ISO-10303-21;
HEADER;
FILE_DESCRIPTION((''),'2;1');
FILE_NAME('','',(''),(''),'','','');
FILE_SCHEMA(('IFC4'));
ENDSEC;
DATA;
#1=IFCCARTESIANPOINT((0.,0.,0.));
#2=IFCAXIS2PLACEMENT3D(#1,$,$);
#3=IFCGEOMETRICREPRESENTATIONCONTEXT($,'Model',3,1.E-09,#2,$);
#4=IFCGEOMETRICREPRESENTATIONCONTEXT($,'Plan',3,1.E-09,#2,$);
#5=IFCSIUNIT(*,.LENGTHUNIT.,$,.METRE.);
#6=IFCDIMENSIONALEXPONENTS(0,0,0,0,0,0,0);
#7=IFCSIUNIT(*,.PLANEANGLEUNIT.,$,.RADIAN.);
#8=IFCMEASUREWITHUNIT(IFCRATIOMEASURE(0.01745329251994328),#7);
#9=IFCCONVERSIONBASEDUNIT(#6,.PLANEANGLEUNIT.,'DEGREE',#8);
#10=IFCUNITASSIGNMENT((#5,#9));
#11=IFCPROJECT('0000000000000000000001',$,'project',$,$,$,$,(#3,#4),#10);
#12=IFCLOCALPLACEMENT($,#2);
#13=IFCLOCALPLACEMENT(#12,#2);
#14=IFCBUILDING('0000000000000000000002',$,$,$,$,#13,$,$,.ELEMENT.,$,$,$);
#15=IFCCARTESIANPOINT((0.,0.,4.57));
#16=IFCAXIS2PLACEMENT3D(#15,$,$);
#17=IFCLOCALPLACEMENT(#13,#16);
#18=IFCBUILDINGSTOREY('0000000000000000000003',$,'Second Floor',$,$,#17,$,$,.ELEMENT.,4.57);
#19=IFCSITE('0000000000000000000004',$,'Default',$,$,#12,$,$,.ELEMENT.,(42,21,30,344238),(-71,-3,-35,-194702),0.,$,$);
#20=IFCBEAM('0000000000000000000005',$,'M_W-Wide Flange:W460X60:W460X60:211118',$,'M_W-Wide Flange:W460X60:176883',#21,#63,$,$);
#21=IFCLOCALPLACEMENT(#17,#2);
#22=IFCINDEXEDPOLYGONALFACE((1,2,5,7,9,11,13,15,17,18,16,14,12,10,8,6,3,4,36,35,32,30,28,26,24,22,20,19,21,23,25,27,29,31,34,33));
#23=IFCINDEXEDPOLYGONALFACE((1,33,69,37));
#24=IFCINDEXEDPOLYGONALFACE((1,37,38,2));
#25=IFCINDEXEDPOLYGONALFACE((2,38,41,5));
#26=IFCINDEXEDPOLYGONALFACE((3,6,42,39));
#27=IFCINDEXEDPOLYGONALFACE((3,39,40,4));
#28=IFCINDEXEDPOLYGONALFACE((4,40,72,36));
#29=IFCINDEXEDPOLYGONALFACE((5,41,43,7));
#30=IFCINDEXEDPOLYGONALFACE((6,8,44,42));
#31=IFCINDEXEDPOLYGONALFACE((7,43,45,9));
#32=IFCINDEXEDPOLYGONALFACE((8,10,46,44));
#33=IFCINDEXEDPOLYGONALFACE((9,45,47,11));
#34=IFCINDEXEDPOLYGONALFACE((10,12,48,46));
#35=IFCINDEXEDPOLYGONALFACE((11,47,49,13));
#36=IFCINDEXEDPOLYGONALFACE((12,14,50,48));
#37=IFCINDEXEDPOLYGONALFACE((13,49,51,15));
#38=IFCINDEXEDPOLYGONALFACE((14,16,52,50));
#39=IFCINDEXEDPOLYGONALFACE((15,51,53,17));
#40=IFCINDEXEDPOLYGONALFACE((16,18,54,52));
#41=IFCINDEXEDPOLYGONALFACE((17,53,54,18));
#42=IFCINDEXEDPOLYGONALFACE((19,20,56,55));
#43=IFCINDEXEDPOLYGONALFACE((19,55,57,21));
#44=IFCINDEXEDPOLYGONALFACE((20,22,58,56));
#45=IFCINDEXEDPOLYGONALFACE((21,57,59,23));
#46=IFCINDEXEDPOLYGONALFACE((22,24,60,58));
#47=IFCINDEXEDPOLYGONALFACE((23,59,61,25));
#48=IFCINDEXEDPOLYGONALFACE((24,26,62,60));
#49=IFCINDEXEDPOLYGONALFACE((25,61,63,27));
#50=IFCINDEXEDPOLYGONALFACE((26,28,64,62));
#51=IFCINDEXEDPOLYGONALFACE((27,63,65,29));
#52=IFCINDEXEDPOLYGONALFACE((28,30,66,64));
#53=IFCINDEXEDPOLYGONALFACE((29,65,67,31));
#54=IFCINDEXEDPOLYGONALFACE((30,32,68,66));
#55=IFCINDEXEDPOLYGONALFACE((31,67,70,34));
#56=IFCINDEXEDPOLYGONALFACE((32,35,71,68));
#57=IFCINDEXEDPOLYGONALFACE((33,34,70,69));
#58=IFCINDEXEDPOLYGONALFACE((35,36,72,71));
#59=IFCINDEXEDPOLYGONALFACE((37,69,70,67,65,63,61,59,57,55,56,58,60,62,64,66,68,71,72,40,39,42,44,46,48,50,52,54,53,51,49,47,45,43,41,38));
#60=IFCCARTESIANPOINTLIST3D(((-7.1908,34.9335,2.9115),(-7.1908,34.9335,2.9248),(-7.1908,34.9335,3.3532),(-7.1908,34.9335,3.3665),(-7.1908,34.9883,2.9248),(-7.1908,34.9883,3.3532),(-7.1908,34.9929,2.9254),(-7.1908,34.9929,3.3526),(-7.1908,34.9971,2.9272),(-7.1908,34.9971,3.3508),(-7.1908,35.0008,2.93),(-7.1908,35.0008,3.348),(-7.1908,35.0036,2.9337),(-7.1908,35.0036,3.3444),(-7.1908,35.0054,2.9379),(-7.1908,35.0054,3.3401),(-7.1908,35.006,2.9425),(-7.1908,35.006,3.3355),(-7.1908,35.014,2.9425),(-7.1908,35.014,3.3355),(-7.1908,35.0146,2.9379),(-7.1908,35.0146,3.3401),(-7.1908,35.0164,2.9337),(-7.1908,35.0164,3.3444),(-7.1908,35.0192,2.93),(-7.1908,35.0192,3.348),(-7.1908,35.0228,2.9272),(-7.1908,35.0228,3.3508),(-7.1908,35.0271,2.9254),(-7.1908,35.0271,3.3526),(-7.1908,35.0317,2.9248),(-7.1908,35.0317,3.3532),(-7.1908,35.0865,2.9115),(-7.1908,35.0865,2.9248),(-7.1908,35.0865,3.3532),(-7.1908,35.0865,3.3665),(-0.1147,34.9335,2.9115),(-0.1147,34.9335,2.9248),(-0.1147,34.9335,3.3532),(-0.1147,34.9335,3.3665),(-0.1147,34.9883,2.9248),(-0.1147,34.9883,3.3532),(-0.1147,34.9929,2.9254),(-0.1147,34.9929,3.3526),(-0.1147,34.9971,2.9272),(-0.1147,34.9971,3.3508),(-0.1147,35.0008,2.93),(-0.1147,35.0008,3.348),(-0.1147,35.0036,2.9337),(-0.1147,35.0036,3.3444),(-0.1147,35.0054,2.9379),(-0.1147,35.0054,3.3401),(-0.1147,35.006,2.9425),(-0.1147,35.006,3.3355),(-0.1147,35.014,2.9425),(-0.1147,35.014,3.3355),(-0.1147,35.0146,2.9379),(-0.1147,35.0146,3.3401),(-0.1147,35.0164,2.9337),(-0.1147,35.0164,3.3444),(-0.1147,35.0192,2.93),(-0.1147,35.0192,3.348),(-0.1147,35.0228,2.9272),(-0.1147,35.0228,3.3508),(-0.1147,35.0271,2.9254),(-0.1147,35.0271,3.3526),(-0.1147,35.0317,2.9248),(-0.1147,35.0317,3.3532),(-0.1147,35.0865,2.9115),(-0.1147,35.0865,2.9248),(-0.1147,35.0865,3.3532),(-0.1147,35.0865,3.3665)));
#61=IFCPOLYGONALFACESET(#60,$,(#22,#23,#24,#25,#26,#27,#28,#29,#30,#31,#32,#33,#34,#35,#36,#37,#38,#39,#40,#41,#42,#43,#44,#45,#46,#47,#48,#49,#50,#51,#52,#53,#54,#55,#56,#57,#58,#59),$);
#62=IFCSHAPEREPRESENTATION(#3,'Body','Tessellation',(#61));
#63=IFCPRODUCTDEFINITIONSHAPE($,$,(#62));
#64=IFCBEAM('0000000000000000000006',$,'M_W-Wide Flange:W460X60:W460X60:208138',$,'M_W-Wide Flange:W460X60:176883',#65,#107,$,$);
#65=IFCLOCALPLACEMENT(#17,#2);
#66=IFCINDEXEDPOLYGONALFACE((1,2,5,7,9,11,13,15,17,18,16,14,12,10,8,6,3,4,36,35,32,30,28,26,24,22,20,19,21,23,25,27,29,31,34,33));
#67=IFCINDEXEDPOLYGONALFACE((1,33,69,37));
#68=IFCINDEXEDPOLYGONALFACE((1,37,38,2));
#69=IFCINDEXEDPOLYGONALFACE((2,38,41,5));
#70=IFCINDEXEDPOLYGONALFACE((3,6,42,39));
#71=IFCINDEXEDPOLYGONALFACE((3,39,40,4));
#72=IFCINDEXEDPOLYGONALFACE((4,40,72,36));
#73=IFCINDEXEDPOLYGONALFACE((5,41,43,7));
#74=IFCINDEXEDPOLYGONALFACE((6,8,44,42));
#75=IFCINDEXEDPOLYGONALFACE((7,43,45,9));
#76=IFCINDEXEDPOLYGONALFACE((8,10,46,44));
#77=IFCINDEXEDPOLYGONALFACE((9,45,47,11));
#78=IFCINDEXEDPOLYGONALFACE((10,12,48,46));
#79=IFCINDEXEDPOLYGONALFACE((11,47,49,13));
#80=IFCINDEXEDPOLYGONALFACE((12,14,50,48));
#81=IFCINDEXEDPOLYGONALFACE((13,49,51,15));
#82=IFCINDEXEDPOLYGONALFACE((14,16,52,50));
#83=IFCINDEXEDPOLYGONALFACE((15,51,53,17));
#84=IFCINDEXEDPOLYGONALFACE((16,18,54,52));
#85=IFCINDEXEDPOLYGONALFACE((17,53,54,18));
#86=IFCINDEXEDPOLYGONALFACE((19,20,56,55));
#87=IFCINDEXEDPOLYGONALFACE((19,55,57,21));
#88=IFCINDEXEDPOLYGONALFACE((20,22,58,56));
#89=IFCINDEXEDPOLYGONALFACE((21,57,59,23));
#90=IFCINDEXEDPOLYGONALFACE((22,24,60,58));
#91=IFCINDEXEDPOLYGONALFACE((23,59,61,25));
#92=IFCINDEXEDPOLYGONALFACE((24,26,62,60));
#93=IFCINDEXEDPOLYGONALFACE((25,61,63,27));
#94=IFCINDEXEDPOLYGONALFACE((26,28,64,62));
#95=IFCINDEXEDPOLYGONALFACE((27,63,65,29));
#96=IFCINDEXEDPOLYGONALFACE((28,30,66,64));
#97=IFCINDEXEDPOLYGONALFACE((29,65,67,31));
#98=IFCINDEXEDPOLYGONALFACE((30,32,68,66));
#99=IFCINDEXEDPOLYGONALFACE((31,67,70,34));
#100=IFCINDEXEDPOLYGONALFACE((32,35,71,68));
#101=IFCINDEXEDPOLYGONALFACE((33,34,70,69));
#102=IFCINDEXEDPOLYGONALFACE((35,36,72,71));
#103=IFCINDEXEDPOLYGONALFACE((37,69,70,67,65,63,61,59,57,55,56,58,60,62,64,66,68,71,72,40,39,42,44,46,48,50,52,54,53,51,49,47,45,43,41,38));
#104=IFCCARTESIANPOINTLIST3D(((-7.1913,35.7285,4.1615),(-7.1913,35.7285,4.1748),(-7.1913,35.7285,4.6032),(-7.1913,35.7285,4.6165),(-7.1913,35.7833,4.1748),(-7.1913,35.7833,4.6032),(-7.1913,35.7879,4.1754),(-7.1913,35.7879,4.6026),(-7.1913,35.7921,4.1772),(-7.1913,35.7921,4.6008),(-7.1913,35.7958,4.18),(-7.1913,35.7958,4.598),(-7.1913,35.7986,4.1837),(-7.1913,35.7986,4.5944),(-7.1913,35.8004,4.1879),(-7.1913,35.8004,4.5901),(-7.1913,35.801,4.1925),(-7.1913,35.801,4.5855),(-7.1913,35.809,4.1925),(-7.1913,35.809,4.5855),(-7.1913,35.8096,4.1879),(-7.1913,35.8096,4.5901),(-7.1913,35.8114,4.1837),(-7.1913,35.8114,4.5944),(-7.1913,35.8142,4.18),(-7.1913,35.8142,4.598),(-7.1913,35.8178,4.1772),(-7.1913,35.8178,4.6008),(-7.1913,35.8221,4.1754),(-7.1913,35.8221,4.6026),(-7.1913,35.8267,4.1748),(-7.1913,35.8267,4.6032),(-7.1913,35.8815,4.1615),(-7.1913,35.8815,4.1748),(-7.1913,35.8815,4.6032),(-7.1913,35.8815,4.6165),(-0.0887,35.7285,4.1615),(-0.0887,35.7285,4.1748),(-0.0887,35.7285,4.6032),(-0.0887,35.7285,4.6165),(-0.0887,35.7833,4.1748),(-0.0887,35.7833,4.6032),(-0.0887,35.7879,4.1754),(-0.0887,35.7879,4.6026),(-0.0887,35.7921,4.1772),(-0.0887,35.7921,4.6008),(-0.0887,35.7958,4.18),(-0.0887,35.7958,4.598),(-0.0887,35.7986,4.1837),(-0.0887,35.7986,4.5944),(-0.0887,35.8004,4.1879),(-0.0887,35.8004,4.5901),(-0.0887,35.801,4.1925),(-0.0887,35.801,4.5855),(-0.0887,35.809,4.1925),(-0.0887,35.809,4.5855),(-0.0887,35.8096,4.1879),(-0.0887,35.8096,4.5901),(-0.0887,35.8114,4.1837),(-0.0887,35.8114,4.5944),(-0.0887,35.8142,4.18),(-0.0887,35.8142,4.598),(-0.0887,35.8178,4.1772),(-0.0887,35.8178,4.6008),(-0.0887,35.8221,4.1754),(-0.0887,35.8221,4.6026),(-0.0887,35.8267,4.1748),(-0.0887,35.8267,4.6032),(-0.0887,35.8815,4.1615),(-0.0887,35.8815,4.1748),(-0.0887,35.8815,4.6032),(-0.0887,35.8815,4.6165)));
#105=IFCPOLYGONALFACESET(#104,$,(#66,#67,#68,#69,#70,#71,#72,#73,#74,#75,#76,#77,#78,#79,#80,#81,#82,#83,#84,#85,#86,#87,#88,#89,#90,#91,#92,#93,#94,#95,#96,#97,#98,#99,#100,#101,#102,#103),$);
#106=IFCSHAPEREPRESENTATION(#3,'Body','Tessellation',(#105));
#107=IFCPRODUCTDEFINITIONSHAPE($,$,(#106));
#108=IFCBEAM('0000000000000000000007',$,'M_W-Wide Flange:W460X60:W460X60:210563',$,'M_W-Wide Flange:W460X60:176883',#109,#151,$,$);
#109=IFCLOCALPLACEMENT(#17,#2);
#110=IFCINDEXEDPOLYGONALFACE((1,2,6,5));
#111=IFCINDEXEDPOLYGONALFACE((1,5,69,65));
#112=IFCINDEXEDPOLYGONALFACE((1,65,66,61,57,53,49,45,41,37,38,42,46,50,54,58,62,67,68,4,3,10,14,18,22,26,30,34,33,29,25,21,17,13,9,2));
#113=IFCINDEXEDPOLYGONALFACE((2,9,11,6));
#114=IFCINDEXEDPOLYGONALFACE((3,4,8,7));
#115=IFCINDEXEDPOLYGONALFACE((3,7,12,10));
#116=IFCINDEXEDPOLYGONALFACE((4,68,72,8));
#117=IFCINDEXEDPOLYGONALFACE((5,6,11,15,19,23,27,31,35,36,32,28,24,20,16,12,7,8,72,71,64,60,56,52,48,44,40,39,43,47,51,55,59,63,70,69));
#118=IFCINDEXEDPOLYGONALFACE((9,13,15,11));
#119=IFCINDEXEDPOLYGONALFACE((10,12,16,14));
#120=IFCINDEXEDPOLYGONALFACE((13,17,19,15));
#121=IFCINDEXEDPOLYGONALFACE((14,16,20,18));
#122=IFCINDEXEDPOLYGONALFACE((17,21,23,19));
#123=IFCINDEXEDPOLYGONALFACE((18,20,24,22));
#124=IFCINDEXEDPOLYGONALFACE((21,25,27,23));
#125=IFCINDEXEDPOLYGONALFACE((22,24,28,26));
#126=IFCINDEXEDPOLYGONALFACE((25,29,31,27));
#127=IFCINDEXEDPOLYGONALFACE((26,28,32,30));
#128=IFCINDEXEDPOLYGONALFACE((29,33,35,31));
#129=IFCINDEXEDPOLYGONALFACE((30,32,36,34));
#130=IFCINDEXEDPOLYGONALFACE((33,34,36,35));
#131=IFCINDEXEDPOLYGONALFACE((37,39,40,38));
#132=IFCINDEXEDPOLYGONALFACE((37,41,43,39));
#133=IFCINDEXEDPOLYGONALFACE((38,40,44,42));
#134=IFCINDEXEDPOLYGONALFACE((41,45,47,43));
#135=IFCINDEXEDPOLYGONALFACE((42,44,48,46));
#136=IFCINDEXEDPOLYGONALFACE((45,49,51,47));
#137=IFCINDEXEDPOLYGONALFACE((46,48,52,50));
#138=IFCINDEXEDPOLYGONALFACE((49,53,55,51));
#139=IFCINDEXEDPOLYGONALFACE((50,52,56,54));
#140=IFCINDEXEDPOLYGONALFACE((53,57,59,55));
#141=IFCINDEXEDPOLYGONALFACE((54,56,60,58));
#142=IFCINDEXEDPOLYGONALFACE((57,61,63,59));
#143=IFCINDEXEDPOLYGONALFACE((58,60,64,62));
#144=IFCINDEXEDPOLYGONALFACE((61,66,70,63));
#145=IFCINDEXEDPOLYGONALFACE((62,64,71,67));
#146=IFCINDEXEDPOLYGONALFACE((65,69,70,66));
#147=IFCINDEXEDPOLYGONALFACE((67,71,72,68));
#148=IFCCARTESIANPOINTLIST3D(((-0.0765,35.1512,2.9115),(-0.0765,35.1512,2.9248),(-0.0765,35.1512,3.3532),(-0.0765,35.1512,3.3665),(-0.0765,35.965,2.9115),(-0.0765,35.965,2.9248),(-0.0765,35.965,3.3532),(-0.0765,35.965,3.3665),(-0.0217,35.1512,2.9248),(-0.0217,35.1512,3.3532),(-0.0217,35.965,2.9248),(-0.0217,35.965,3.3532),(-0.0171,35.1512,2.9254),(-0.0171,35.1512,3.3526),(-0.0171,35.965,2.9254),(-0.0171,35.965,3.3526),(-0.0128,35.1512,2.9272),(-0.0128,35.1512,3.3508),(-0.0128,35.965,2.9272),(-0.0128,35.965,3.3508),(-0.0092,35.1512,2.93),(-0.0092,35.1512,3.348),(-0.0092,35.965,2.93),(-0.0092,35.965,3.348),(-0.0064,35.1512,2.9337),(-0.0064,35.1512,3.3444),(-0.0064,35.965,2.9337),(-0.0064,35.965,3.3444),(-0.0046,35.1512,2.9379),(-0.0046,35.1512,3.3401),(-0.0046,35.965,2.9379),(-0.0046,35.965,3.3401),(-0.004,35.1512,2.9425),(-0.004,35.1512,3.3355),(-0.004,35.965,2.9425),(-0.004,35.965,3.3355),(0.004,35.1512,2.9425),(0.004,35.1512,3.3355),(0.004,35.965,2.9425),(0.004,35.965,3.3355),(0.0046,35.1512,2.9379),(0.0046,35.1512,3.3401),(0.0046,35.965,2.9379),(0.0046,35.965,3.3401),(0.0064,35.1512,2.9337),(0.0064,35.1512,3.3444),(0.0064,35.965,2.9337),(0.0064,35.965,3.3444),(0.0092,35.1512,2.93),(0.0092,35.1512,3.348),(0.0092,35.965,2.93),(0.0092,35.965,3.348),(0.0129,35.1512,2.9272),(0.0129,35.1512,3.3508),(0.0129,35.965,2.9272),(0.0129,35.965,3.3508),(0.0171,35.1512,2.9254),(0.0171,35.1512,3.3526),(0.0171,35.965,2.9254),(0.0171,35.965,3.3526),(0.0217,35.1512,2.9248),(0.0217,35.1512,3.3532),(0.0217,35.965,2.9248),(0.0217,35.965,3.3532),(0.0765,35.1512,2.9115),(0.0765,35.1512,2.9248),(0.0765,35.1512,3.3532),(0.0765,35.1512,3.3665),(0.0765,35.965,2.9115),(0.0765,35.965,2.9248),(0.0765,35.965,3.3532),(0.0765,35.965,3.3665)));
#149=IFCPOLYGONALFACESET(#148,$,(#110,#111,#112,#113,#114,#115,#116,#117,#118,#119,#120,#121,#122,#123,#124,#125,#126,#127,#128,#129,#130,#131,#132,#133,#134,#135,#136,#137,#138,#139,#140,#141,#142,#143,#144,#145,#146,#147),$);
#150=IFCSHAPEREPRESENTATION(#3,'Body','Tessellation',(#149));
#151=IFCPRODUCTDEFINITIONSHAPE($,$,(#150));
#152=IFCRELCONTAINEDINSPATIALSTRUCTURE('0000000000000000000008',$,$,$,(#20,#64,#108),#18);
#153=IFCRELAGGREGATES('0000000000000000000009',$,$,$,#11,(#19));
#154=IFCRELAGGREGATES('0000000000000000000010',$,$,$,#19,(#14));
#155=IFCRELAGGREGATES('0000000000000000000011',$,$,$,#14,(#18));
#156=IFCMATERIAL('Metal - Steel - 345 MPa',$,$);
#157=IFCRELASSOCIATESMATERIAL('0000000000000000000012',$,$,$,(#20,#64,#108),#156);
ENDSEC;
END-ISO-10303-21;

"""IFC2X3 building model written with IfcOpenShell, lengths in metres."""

from ifc_helpers import new_model, entity, si_unit, converted_unit, frame, frame_2d, origin, place, context, project, spatial, polyline, circle_curve, parameter, trimmed, segment, composite_curve, outline, extrude, material, element, save


model = new_model("IFC2X3")

# Units and contexts
model_context = context("Model", 3, precision=1e-09, world=origin())
plan_context = context("Plan", 3, precision=1e-09, world=origin())
ifc_project = project(units=[si_unit("LENGTHUNIT", "METRE"), converted_unit("PLANEANGLEUNIT", "DEGREE", entity("IfcRatioMeasure", 0.01745329251994328), si_unit("PLANEANGLEUNIT", "RADIAN"), dimensions=[0, 0, 0, 0, 0, 0, 0])], contexts=[model_context, plan_context])

# Site, building, storey
site_placement = place(None, origin())
site = spatial("IfcSite", under=ifc_project, at=site_placement, Name="Default", CompositionType="ELEMENT", RefLatitude=(42, 21, 30, 344238), RefLongitude=(-71, -3, -35, -194702), RefElevation=0.0)
building_placement = place(site_placement, origin())
building = spatial("IfcBuilding", under=site, at=building_placement, CompositionType="ELEMENT")
storey_placement = place(building_placement, frame((0.0, 0.0, 4.57)))
storey = spatial("IfcBuildingStorey", under=building, at=storey_placement, Name="Second Floor", CompositionType="ELEMENT", Elevation=4.57)

# Shared definitions
ifc_material = material(Name="Metal - Steel - 345 MPa")

# Beams
beam_1_placement = place(storey_placement, frame((-7.2774, 35.01, 3.3665), z_axis=(0.0, 0.0, 1.0), x_axis=(0.0, -1.0, 0.0)))
element("IfcBeam", 1, at=beam_1_placement, inside=storey, material=ifc_material, Name="M_W-Wide Flange:W460X60:W460X60:211118", ObjectType="M_W-Wide Flange:W460X60:176883", context=model_context, shape_type="SweptSolid", body=[
    extrude(outline(composite_curve([segment(polyline([(-0.0765, -0.2142), (-0.0765, -0.2275)]), True, "CONTINUOUS"), segment(polyline([(-0.0765, -0.2275), (0.0765, -0.2275)]), True, "CONTINUOUS"), segment(polyline([(0.0765, -0.2275), (0.0765, -0.2142)]), True, "CONTINUOUS"), segment(polyline([(0.0765, -0.2142), (0.0217, -0.2142)]), True, "CONTINUOUS"), segment(trimmed(circle_curve(frame_2d((0.0217, -0.1965), x_axis=(1.0, 0.0)), 0.0177), [parameter(180.0)], [parameter(270.0)], True, "PARAMETER"), False, "CONTINUOUS"), segment(polyline([(0.004, -0.1965), (0.004, 0.1965)]), True, "CONTINUOUS"), segment(trimmed(circle_curve(frame_2d((0.0217, 0.1965), x_axis=(1.0, 0.0)), 0.0177), [parameter(90.0)], [parameter(180.0)], True, "PARAMETER"), False, "CONTINUOUS"), segment(polyline([(0.0217, 0.2142), (0.0765, 0.2142)]), True, "CONTINUOUS"), segment(polyline([(0.0765, 0.2142), (0.0765, 0.2275)]), True, "CONTINUOUS"), segment(polyline([(0.0765, 0.2275), (-0.0765, 0.2275)]), True, "CONTINUOUS"), segment(polyline([(-0.0765, 0.2275), (-0.0765, 0.2142)]), True, "CONTINUOUS"), segment(polyline([(-0.0765, 0.2142), (-0.0217, 0.2142)]), True, "CONTINUOUS"), segment(trimmed(circle_curve(frame_2d((-0.0217, 0.1965), x_axis=(1.0, 0.0)), 0.0177), [parameter(360.0)], [parameter(90.0)], True, "PARAMETER"), False, "CONTINUOUS"), segment(polyline([(-0.004, 0.1965), (-0.004, -0.1965)]), True, "CONTINUOUS"), segment(trimmed(circle_curve(frame_2d((-0.0217, -0.1965), x_axis=(1.0, 0.0)), 0.0177), [parameter(270.0)], [parameter(0.0)], True, "PARAMETER"), False, "CONTINUOUS"), segment(polyline([(-0.0217, -0.2142), (-0.0765, -0.2142)]), True, "CONTINUOUS")], self_intersect=False)), frame((0.0, 0.0866, -0.2275), z_axis=(0.0, -1.0, 0.0), x_axis=(1.0, 0.0, 0.0)), (0.0, 0.0, -1.0), 7.0761),
])
beam_2_placement = place(storey_placement, frame((-7.2774, 35.805, 4.6165), z_axis=(0.0, 0.0, 1.0), x_axis=(0.0, -1.0, 0.0)))
element("IfcBeam", 2, at=beam_2_placement, inside=storey, material=ifc_material, Name="M_W-Wide Flange:W460X60:W460X60:208138", ObjectType="M_W-Wide Flange:W460X60:176883", context=model_context, shape_type="SweptSolid", body=[
    extrude(outline(composite_curve([segment(polyline([(-0.0765, -0.2142), (-0.0765, -0.2275)]), True, "CONTINUOUS"), segment(polyline([(-0.0765, -0.2275), (0.0765, -0.2275)]), True, "CONTINUOUS"), segment(polyline([(0.0765, -0.2275), (0.0765, -0.2142)]), True, "CONTINUOUS"), segment(polyline([(0.0765, -0.2142), (0.0217, -0.2142)]), True, "CONTINUOUS"), segment(trimmed(circle_curve(frame_2d((0.0217, -0.1965), x_axis=(1.0, 0.0)), 0.0177), [parameter(180.0)], [parameter(270.0)], True, "PARAMETER"), False, "CONTINUOUS"), segment(polyline([(0.004, -0.1965), (0.004, 0.1965)]), True, "CONTINUOUS"), segment(trimmed(circle_curve(frame_2d((0.0217, 0.1965), x_axis=(1.0, 0.0)), 0.0177), [parameter(90.0)], [parameter(180.0)], True, "PARAMETER"), False, "CONTINUOUS"), segment(polyline([(0.0217, 0.2142), (0.0765, 0.2142)]), True, "CONTINUOUS"), segment(polyline([(0.0765, 0.2142), (0.0765, 0.2275)]), True, "CONTINUOUS"), segment(polyline([(0.0765, 0.2275), (-0.0765, 0.2275)]), True, "CONTINUOUS"), segment(polyline([(-0.0765, 0.2275), (-0.0765, 0.2142)]), True, "CONTINUOUS"), segment(polyline([(-0.0765, 0.2142), (-0.0217, 0.2142)]), True, "CONTINUOUS"), segment(trimmed(circle_curve(frame_2d((-0.0217, 0.1965), x_axis=(1.0, 0.0)), 0.0177), [parameter(360.0)], [parameter(90.0)], True, "PARAMETER"), False, "CONTINUOUS"), segment(polyline([(-0.004, 0.1965), (-0.004, -0.1965)]), True, "CONTINUOUS"), segment(trimmed(circle_curve(frame_2d((-0.0217, -0.1965), x_axis=(1.0, 0.0)), 0.0177), [parameter(270.0)], [parameter(0.0)], True, "PARAMETER"), False, "CONTINUOUS"), segment(polyline([(-0.0217, -0.2142), (-0.0765, -0.2142)]), True, "CONTINUOUS")], self_intersect=False)), frame((0.0, 0.0861, -0.2275), z_axis=(0.0, -1.0, 0.0), x_axis=(1.0, 0.0, 0.0)), (0.0, 0.0, -1.0), 7.1026),
])
beam_3_placement = place(storey_placement, frame((0.0, 35.0646, 3.3665), z_axis=(0.0, 0.0, 1.0), x_axis=(-1.0, 0.0, 0.0)))
element("IfcBeam", 3, at=beam_3_placement, inside=storey, material=ifc_material, Name="M_W-Wide Flange:W460X60:W460X60:210563", ObjectType="M_W-Wide Flange:W460X60:176883", context=model_context, shape_type="SweptSolid", body=[
    extrude(outline(composite_curve([segment(polyline([(0.2142, -0.0765), (0.2275, -0.0765)]), True, "CONTINUOUS"), segment(polyline([(0.2275, -0.0765), (0.2275, 0.0765)]), True, "CONTINUOUS"), segment(polyline([(0.2275, 0.0765), (0.2142, 0.0765)]), True, "CONTINUOUS"), segment(polyline([(0.2142, 0.0765), (0.2142, 0.0217)]), True, "CONTINUOUS"), segment(trimmed(circle_curve(frame_2d((0.1965, 0.0217), x_axis=(0.0, 1.0)), 0.0177), [parameter(180.0)], [parameter(270.0)], True, "PARAMETER"), False, "CONTINUOUS"), segment(polyline([(0.1965, 0.004), (-0.1965, 0.004)]), True, "CONTINUOUS"), segment(trimmed(circle_curve(frame_2d((-0.1965, 0.0217), x_axis=(0.0, 1.0)), 0.0177), [parameter(90.0)], [parameter(180.0)], True, "PARAMETER"), False, "CONTINUOUS"), segment(polyline([(-0.2142, 0.0217), (-0.2142, 0.0765)]), True, "CONTINUOUS"), segment(polyline([(-0.2142, 0.0765), (-0.2275, 0.0765)]), True, "CONTINUOUS"), segment(polyline([(-0.2275, 0.0765), (-0.2275, -0.0765)]), True, "CONTINUOUS"), segment(polyline([(-0.2275, -0.0765), (-0.2142, -0.0765)]), True, "CONTINUOUS"), segment(polyline([(-0.2142, -0.0765), (-0.2142, -0.0217)]), True, "CONTINUOUS"), segment(trimmed(circle_curve(frame_2d((-0.1965, -0.0217), x_axis=(0.0, 1.0)), 0.0177), [parameter(360.0)], [parameter(90.0)], True, "PARAMETER"), False, "CONTINUOUS"), segment(polyline([(-0.1965, -0.004), (0.1965, -0.004)]), True, "CONTINUOUS"), segment(trimmed(circle_curve(frame_2d((0.1965, -0.0217), x_axis=(0.0, 1.0)), 0.0177), [parameter(270.0)], [parameter(0.0)], True, "PARAMETER"), False, "CONTINUOUS"), segment(polyline([(0.2142, -0.0217), (0.2142, -0.0765)]), True, "CONTINUOUS")], self_intersect=False)), frame((0.0, -0.0866, -0.2275), z_axis=(0.0, -1.0, 0.0), x_axis=(0.0, 0.0, -1.0)), (0.0, 0.0, 1.0), 0.8138),
])

save(model, "model.ifc")
